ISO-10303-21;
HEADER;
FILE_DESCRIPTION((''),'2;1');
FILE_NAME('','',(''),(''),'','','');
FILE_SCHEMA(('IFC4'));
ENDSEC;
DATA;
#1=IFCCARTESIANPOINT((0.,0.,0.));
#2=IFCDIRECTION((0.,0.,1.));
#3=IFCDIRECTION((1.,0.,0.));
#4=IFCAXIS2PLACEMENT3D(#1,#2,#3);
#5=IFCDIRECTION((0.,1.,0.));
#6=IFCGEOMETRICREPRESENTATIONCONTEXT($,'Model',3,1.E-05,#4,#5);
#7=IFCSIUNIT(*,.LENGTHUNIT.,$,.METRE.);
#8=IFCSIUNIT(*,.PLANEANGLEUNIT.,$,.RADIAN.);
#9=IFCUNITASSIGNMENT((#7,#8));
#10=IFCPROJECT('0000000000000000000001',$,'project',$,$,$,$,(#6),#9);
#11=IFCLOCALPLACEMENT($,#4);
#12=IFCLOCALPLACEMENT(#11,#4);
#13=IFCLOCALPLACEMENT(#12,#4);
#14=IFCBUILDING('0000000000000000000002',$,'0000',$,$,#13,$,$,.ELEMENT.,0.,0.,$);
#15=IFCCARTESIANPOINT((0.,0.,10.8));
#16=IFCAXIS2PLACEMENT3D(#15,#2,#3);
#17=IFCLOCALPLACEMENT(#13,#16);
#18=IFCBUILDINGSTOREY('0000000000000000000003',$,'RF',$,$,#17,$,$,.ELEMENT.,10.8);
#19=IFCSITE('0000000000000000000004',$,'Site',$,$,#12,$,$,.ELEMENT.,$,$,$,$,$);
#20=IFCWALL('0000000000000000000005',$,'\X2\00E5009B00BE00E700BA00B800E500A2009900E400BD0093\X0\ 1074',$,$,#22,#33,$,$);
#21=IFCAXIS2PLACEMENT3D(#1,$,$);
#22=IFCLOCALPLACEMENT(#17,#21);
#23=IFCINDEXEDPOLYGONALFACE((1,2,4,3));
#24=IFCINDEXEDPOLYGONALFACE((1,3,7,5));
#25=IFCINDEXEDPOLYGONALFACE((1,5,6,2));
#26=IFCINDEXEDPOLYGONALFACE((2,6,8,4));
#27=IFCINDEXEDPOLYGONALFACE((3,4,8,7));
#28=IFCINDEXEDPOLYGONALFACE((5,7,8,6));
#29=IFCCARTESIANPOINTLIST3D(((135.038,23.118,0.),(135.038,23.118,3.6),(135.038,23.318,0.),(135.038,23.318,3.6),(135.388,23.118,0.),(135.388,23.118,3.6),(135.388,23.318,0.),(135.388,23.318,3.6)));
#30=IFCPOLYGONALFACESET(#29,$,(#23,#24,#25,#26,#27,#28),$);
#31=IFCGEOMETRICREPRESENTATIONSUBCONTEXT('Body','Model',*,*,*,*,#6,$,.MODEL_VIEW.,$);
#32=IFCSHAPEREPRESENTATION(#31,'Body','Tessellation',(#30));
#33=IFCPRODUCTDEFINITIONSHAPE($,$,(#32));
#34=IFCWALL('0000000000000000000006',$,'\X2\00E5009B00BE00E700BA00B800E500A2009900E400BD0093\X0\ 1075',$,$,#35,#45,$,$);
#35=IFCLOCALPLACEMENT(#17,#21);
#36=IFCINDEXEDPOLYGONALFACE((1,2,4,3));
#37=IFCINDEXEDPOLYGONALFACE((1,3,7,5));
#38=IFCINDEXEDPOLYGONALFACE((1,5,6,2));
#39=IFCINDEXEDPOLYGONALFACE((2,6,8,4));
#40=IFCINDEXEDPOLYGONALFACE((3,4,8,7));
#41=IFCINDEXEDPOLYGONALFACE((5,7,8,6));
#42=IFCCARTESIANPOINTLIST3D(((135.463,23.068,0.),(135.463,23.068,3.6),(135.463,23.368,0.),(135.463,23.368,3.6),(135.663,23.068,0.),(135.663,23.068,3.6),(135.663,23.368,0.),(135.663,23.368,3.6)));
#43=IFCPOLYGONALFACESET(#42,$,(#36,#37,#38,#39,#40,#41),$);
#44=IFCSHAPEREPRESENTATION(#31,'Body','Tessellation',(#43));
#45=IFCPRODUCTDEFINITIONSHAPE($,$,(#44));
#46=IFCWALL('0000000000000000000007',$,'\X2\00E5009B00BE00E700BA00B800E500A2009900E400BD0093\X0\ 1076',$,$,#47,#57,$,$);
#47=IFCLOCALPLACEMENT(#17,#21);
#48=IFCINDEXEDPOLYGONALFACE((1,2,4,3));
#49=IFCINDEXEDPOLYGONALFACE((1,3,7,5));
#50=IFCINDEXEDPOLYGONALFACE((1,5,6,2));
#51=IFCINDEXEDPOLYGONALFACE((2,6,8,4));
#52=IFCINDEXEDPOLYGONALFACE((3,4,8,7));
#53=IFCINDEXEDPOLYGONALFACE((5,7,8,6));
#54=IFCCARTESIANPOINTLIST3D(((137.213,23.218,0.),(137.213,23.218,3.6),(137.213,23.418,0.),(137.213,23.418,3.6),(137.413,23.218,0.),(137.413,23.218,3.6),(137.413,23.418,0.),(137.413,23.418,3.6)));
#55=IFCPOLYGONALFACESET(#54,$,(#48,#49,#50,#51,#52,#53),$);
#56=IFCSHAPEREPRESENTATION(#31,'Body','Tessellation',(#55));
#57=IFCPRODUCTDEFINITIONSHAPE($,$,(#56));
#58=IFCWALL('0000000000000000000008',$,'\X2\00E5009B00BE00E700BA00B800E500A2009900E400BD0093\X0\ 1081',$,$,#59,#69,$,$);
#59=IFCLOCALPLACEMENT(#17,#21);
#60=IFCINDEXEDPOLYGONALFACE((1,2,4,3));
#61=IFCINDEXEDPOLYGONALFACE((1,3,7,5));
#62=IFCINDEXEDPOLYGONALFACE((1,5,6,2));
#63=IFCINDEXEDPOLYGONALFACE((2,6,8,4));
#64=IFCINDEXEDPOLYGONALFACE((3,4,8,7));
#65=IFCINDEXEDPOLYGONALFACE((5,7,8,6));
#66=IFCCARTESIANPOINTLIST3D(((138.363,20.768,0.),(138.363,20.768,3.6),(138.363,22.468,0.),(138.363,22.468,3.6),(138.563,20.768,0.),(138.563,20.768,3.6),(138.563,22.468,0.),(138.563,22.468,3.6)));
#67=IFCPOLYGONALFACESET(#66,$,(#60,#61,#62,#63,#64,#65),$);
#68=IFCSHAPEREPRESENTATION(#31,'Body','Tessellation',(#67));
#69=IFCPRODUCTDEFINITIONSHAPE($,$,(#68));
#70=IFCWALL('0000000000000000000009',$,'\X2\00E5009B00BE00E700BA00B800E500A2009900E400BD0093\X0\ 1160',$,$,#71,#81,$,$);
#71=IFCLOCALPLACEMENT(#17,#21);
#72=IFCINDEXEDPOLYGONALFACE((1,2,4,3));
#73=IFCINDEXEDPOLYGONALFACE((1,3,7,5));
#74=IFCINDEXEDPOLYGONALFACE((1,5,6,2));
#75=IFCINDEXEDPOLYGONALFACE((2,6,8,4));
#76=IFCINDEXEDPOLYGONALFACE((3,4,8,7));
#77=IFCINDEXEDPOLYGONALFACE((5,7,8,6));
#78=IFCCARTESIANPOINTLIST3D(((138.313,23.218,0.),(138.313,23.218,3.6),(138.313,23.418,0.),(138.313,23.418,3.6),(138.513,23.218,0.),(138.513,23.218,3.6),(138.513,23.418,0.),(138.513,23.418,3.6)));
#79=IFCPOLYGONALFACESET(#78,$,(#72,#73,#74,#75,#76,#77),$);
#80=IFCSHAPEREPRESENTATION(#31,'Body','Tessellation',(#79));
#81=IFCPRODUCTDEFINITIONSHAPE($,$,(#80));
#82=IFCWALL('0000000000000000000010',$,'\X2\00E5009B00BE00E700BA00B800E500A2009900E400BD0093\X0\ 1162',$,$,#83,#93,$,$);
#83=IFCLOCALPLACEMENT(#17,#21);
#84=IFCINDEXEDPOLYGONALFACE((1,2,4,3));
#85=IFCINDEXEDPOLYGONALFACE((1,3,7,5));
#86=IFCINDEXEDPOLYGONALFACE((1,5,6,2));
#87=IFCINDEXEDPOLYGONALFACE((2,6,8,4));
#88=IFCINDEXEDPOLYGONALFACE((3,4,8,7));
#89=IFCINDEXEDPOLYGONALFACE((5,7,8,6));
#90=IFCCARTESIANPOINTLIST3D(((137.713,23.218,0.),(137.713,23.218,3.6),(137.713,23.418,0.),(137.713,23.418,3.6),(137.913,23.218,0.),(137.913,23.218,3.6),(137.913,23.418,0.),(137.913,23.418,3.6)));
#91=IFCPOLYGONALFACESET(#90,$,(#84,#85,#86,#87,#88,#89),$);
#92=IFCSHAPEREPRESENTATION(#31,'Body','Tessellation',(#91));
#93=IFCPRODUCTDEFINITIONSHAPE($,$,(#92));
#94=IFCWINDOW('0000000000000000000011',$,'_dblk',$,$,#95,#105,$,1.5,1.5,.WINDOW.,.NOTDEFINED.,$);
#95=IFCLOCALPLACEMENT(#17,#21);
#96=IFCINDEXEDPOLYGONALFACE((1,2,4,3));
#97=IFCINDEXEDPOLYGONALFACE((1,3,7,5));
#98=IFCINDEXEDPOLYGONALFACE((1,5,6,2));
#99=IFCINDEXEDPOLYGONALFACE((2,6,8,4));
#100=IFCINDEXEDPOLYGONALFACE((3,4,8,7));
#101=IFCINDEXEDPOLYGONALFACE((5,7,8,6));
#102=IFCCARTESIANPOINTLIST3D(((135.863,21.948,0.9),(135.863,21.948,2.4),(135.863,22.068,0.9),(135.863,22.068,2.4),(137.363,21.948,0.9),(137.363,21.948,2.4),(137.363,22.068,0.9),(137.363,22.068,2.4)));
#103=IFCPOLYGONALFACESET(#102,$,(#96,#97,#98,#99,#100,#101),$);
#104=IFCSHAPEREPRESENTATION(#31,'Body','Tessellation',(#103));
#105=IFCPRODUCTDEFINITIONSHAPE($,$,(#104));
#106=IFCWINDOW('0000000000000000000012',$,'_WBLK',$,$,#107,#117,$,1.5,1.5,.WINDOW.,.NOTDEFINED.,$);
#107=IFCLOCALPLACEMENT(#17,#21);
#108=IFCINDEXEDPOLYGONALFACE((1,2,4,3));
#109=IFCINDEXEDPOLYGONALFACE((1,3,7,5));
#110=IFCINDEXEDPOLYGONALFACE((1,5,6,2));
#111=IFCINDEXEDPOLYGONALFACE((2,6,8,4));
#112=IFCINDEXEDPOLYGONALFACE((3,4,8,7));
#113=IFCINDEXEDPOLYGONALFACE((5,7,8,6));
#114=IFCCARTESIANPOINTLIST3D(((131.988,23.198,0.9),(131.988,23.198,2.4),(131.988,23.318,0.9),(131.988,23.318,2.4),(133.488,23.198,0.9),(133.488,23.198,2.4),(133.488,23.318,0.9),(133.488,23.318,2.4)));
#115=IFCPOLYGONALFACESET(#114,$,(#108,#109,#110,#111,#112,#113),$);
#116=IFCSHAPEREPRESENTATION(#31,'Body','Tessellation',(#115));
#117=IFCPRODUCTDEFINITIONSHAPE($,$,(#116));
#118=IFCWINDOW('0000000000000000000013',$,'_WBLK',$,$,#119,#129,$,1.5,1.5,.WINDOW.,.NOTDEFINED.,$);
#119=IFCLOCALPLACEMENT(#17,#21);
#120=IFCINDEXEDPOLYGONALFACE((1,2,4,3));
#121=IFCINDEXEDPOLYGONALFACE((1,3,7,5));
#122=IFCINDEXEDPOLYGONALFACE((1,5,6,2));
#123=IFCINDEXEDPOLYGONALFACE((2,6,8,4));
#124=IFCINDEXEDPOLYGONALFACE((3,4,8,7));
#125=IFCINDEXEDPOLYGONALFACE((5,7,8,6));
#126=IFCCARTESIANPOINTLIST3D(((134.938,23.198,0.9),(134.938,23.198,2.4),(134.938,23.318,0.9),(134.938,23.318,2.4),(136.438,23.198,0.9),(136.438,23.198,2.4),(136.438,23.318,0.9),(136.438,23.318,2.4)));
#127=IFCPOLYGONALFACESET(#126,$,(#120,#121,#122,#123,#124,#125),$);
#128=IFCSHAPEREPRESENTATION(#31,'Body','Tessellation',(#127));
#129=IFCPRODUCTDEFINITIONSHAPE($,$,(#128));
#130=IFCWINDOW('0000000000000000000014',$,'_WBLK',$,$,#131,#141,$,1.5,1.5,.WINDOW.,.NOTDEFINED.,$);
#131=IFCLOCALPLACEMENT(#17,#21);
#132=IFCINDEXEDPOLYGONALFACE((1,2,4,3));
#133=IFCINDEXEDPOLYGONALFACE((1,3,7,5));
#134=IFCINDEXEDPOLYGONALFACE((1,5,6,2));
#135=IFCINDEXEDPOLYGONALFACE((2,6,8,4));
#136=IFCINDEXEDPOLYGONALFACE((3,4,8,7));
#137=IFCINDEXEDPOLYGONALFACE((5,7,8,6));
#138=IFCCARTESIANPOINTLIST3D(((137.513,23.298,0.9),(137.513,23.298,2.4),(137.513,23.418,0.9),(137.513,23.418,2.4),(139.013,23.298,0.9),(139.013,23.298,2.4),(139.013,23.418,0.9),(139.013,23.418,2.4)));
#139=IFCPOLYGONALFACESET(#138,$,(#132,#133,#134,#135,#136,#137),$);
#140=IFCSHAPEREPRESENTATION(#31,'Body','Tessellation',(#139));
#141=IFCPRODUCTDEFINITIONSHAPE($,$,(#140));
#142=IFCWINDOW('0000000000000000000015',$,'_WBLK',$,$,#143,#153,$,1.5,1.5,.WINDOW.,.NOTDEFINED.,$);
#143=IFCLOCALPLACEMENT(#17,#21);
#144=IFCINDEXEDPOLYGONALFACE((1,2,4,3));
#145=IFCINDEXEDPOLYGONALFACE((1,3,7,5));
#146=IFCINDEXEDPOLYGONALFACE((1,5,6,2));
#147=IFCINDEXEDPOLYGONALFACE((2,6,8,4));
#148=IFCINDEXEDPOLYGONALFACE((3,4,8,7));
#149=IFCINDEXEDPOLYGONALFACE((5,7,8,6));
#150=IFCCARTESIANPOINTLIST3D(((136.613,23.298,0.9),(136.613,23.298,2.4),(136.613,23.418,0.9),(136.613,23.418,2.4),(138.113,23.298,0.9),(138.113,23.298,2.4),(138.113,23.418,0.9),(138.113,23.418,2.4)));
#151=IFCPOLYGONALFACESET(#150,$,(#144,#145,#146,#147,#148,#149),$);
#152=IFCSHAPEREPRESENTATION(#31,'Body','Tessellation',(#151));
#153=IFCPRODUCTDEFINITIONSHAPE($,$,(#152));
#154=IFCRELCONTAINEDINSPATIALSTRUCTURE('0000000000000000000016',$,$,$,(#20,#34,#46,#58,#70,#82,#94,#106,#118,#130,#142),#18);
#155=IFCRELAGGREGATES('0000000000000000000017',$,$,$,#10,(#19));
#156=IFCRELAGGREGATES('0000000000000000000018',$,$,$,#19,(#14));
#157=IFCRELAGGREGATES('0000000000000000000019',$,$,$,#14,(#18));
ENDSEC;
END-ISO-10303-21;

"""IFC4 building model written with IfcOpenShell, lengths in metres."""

from ifc_helpers import new_model, si_unit, direction, frame, frame_2d, origin_with_axes, place, context, subcontext, project, spatial, rectangle, extrude, element, save


model = new_model("IFC4")

# Units and contexts
model_context = context("Model", 3, precision=1e-05, world=origin_with_axes(), true_north=direction((0.0, 1.0, 0.0)))
body_context = subcontext(model_context, "Body", "Model", "MODEL_VIEW")
ifc_project = project(units=[si_unit("LENGTHUNIT", "METRE"), si_unit("PLANEANGLEUNIT", "RADIAN")], contexts=[model_context])

# Site, building, storey
placement = place(None, origin_with_axes())
site_placement = place(placement, origin_with_axes())
site = spatial("IfcSite", under=ifc_project, at=site_placement, Name="Site", CompositionType="ELEMENT")
building_placement = place(site_placement, origin_with_axes())
building = spatial("IfcBuilding", under=site, at=building_placement, Name="0000", CompositionType="ELEMENT", ElevationOfRefHeight=0.0, ElevationOfTerrain=0.0)
storey_placement = place(building_placement, frame((0.0, 0.0, 10.8), z_axis=(0.0, 0.0, 1.0), x_axis=(1.0, 0.0, 0.0)))
storey = spatial("IfcBuildingStorey", under=building, at=storey_placement, Name="RF", CompositionType="ELEMENT", Elevation=10.8)

# Walls
for number, where, z_axis, x_axis, name in (
    (1, (135.213, 23.218, 0.0), (0.0, 0.0, 1.0), (1.0, 0.0, 0.0), "å\u009b¾çº¸å¢\u0099ä½\u0093 1074"),
):
    element("IfcWall", number, at=place(storey_placement, frame(where, z_axis=z_axis, x_axis=x_axis)), inside=storey, Name=name, context=body_context, shape_type="SweptSolid", body=[
        extrude(rectangle(XDim=0.35, YDim=0.2, at=frame_2d((0.0, 0.0), x_axis=(1.0, 0.0, 0.0))), frame((0.0, 0.0, 0.0), z_axis=(0.0, 0.0, 1.0)), (0.0, 0.0, 1.0), 3.6),
    ])
wall_1_placement = place(storey_placement, frame((135.563, 23.218, 0.0), z_axis=(0.0, 0.0, 1.0), x_axis=(0.0, 1.0, 0.0)))
element("IfcWall", 2, at=wall_1_placement, inside=storey, Name="å\u009b¾çº¸å¢\u0099ä½\u0093 1075", context=body_context, shape_type="SweptSolid", body=[
    extrude(rectangle(XDim=0.3, YDim=0.2, at=frame_2d((0.0, 0.0), x_axis=(1.0, 0.0, 0.0))), frame((0.0, 0.0, 0.0), z_axis=(0.0, 0.0, 1.0)), (0.0, 0.0, 1.0), 3.6),
])
wall_2_placement = place(storey_placement, frame((137.313, 23.318, 0.0), z_axis=(0.0, 0.0, 1.0), x_axis=(0.0, 1.0, 0.0)))
element("IfcWall", 3, at=wall_2_placement, inside=storey, Name="å\u009b¾çº¸å¢\u0099ä½\u0093 1076", context=body_context, shape_type="SweptSolid", body=[
    extrude(rectangle(XDim=0.2, YDim=0.2, at=frame_2d((0.0, 0.0), x_axis=(1.0, 0.0, 0.0))), frame((0.0, 0.0, 0.0), z_axis=(0.0, 0.0, 1.0)), (0.0, 0.0, 1.0), 3.6),
])
wall_3_placement = place(storey_placement, frame((138.463, 21.618, 0.0), z_axis=(0.0, 0.0, 1.0), x_axis=(0.0, 1.0, 0.0)))
element("IfcWall", 4, at=wall_3_placement, inside=storey, Name="å\u009b¾çº¸å¢\u0099ä½\u0093 1081", context=body_context, shape_type="SweptSolid", body=[
    extrude(rectangle(XDim=1.7, YDim=0.2, at=frame_2d((0.0, 0.0), x_axis=(1.0, 0.0, 0.0))), frame((0.0, 0.0, 0.0), z_axis=(0.0, 0.0, 1.0)), (0.0, 0.0, 1.0), 3.6),
])
for number, where, z_axis, x_axis, name in (
    (5, (138.413, 23.318, 0.0), (0.0, 0.0, 1.0), (1.0, 0.0, 0.0), "å\u009b¾çº¸å¢\u0099ä½\u0093 1160"),
    (6, (137.813, 23.318, 0.0), (0.0, 0.0, 1.0), (0.0, 1.0, 0.0), "å\u009b¾çº¸å¢\u0099ä½\u0093 1162"),
):
    element("IfcWall", number, at=place(storey_placement, frame(where, z_axis=z_axis, x_axis=x_axis)), inside=storey, Name=name, context=body_context, shape_type="SweptSolid", body=[
        extrude(rectangle(XDim=0.2, YDim=0.2, at=frame_2d((0.0, 0.0), x_axis=(1.0, 0.0, 0.0))), frame((0.0, 0.0, 0.0), z_axis=(0.0, 0.0, 1.0)), (0.0, 0.0, 1.0), 3.6),
    ])

# Windows
for number, where, z_axis, x_axis, name in (
    (7, (136.613, 22.008, 0.9), (0.0, 0.0, 1.0), (1.0, 0.0, 0.0), "_dblk"),
    (8, (132.738, 23.258, 0.9), (0.0, 0.0, 1.0), (1.0, 0.0, 0.0), "_WBLK"),
    (9, (135.688, 23.258, 0.9), (0.0, 0.0, 1.0), (1.0, 0.0, 0.0), "_WBLK"),
    (10, (138.263, 23.358, 0.9), (0.0, 0.0, 1.0), (1.0, 0.0, 0.0), "_WBLK"),
    (11, (137.363, 23.358, 0.9), (0.0, 0.0, 1.0), (1.0, 0.0, 0.0), "_WBLK"),
):
    element("IfcWindow", number, at=place(storey_placement, frame(where, z_axis=z_axis, x_axis=x_axis)), inside=storey, Name=name, OverallHeight=1.5, OverallWidth=1.5, PartitioningType="NOTDEFINED", PredefinedType="WINDOW", context=body_context, shape_type="SweptSolid", body=[
        extrude(rectangle(XDim=1.5, YDim=0.12, at=frame_2d((0.0, 0.0), x_axis=(1.0, 0.0, 0.0))), frame((0.0, 0.0, 0.0), z_axis=(0.0, 0.0, 1.0)), (0.0, 0.0, 1.0), 1.5),
    ])

save(model, "model.ifc")
